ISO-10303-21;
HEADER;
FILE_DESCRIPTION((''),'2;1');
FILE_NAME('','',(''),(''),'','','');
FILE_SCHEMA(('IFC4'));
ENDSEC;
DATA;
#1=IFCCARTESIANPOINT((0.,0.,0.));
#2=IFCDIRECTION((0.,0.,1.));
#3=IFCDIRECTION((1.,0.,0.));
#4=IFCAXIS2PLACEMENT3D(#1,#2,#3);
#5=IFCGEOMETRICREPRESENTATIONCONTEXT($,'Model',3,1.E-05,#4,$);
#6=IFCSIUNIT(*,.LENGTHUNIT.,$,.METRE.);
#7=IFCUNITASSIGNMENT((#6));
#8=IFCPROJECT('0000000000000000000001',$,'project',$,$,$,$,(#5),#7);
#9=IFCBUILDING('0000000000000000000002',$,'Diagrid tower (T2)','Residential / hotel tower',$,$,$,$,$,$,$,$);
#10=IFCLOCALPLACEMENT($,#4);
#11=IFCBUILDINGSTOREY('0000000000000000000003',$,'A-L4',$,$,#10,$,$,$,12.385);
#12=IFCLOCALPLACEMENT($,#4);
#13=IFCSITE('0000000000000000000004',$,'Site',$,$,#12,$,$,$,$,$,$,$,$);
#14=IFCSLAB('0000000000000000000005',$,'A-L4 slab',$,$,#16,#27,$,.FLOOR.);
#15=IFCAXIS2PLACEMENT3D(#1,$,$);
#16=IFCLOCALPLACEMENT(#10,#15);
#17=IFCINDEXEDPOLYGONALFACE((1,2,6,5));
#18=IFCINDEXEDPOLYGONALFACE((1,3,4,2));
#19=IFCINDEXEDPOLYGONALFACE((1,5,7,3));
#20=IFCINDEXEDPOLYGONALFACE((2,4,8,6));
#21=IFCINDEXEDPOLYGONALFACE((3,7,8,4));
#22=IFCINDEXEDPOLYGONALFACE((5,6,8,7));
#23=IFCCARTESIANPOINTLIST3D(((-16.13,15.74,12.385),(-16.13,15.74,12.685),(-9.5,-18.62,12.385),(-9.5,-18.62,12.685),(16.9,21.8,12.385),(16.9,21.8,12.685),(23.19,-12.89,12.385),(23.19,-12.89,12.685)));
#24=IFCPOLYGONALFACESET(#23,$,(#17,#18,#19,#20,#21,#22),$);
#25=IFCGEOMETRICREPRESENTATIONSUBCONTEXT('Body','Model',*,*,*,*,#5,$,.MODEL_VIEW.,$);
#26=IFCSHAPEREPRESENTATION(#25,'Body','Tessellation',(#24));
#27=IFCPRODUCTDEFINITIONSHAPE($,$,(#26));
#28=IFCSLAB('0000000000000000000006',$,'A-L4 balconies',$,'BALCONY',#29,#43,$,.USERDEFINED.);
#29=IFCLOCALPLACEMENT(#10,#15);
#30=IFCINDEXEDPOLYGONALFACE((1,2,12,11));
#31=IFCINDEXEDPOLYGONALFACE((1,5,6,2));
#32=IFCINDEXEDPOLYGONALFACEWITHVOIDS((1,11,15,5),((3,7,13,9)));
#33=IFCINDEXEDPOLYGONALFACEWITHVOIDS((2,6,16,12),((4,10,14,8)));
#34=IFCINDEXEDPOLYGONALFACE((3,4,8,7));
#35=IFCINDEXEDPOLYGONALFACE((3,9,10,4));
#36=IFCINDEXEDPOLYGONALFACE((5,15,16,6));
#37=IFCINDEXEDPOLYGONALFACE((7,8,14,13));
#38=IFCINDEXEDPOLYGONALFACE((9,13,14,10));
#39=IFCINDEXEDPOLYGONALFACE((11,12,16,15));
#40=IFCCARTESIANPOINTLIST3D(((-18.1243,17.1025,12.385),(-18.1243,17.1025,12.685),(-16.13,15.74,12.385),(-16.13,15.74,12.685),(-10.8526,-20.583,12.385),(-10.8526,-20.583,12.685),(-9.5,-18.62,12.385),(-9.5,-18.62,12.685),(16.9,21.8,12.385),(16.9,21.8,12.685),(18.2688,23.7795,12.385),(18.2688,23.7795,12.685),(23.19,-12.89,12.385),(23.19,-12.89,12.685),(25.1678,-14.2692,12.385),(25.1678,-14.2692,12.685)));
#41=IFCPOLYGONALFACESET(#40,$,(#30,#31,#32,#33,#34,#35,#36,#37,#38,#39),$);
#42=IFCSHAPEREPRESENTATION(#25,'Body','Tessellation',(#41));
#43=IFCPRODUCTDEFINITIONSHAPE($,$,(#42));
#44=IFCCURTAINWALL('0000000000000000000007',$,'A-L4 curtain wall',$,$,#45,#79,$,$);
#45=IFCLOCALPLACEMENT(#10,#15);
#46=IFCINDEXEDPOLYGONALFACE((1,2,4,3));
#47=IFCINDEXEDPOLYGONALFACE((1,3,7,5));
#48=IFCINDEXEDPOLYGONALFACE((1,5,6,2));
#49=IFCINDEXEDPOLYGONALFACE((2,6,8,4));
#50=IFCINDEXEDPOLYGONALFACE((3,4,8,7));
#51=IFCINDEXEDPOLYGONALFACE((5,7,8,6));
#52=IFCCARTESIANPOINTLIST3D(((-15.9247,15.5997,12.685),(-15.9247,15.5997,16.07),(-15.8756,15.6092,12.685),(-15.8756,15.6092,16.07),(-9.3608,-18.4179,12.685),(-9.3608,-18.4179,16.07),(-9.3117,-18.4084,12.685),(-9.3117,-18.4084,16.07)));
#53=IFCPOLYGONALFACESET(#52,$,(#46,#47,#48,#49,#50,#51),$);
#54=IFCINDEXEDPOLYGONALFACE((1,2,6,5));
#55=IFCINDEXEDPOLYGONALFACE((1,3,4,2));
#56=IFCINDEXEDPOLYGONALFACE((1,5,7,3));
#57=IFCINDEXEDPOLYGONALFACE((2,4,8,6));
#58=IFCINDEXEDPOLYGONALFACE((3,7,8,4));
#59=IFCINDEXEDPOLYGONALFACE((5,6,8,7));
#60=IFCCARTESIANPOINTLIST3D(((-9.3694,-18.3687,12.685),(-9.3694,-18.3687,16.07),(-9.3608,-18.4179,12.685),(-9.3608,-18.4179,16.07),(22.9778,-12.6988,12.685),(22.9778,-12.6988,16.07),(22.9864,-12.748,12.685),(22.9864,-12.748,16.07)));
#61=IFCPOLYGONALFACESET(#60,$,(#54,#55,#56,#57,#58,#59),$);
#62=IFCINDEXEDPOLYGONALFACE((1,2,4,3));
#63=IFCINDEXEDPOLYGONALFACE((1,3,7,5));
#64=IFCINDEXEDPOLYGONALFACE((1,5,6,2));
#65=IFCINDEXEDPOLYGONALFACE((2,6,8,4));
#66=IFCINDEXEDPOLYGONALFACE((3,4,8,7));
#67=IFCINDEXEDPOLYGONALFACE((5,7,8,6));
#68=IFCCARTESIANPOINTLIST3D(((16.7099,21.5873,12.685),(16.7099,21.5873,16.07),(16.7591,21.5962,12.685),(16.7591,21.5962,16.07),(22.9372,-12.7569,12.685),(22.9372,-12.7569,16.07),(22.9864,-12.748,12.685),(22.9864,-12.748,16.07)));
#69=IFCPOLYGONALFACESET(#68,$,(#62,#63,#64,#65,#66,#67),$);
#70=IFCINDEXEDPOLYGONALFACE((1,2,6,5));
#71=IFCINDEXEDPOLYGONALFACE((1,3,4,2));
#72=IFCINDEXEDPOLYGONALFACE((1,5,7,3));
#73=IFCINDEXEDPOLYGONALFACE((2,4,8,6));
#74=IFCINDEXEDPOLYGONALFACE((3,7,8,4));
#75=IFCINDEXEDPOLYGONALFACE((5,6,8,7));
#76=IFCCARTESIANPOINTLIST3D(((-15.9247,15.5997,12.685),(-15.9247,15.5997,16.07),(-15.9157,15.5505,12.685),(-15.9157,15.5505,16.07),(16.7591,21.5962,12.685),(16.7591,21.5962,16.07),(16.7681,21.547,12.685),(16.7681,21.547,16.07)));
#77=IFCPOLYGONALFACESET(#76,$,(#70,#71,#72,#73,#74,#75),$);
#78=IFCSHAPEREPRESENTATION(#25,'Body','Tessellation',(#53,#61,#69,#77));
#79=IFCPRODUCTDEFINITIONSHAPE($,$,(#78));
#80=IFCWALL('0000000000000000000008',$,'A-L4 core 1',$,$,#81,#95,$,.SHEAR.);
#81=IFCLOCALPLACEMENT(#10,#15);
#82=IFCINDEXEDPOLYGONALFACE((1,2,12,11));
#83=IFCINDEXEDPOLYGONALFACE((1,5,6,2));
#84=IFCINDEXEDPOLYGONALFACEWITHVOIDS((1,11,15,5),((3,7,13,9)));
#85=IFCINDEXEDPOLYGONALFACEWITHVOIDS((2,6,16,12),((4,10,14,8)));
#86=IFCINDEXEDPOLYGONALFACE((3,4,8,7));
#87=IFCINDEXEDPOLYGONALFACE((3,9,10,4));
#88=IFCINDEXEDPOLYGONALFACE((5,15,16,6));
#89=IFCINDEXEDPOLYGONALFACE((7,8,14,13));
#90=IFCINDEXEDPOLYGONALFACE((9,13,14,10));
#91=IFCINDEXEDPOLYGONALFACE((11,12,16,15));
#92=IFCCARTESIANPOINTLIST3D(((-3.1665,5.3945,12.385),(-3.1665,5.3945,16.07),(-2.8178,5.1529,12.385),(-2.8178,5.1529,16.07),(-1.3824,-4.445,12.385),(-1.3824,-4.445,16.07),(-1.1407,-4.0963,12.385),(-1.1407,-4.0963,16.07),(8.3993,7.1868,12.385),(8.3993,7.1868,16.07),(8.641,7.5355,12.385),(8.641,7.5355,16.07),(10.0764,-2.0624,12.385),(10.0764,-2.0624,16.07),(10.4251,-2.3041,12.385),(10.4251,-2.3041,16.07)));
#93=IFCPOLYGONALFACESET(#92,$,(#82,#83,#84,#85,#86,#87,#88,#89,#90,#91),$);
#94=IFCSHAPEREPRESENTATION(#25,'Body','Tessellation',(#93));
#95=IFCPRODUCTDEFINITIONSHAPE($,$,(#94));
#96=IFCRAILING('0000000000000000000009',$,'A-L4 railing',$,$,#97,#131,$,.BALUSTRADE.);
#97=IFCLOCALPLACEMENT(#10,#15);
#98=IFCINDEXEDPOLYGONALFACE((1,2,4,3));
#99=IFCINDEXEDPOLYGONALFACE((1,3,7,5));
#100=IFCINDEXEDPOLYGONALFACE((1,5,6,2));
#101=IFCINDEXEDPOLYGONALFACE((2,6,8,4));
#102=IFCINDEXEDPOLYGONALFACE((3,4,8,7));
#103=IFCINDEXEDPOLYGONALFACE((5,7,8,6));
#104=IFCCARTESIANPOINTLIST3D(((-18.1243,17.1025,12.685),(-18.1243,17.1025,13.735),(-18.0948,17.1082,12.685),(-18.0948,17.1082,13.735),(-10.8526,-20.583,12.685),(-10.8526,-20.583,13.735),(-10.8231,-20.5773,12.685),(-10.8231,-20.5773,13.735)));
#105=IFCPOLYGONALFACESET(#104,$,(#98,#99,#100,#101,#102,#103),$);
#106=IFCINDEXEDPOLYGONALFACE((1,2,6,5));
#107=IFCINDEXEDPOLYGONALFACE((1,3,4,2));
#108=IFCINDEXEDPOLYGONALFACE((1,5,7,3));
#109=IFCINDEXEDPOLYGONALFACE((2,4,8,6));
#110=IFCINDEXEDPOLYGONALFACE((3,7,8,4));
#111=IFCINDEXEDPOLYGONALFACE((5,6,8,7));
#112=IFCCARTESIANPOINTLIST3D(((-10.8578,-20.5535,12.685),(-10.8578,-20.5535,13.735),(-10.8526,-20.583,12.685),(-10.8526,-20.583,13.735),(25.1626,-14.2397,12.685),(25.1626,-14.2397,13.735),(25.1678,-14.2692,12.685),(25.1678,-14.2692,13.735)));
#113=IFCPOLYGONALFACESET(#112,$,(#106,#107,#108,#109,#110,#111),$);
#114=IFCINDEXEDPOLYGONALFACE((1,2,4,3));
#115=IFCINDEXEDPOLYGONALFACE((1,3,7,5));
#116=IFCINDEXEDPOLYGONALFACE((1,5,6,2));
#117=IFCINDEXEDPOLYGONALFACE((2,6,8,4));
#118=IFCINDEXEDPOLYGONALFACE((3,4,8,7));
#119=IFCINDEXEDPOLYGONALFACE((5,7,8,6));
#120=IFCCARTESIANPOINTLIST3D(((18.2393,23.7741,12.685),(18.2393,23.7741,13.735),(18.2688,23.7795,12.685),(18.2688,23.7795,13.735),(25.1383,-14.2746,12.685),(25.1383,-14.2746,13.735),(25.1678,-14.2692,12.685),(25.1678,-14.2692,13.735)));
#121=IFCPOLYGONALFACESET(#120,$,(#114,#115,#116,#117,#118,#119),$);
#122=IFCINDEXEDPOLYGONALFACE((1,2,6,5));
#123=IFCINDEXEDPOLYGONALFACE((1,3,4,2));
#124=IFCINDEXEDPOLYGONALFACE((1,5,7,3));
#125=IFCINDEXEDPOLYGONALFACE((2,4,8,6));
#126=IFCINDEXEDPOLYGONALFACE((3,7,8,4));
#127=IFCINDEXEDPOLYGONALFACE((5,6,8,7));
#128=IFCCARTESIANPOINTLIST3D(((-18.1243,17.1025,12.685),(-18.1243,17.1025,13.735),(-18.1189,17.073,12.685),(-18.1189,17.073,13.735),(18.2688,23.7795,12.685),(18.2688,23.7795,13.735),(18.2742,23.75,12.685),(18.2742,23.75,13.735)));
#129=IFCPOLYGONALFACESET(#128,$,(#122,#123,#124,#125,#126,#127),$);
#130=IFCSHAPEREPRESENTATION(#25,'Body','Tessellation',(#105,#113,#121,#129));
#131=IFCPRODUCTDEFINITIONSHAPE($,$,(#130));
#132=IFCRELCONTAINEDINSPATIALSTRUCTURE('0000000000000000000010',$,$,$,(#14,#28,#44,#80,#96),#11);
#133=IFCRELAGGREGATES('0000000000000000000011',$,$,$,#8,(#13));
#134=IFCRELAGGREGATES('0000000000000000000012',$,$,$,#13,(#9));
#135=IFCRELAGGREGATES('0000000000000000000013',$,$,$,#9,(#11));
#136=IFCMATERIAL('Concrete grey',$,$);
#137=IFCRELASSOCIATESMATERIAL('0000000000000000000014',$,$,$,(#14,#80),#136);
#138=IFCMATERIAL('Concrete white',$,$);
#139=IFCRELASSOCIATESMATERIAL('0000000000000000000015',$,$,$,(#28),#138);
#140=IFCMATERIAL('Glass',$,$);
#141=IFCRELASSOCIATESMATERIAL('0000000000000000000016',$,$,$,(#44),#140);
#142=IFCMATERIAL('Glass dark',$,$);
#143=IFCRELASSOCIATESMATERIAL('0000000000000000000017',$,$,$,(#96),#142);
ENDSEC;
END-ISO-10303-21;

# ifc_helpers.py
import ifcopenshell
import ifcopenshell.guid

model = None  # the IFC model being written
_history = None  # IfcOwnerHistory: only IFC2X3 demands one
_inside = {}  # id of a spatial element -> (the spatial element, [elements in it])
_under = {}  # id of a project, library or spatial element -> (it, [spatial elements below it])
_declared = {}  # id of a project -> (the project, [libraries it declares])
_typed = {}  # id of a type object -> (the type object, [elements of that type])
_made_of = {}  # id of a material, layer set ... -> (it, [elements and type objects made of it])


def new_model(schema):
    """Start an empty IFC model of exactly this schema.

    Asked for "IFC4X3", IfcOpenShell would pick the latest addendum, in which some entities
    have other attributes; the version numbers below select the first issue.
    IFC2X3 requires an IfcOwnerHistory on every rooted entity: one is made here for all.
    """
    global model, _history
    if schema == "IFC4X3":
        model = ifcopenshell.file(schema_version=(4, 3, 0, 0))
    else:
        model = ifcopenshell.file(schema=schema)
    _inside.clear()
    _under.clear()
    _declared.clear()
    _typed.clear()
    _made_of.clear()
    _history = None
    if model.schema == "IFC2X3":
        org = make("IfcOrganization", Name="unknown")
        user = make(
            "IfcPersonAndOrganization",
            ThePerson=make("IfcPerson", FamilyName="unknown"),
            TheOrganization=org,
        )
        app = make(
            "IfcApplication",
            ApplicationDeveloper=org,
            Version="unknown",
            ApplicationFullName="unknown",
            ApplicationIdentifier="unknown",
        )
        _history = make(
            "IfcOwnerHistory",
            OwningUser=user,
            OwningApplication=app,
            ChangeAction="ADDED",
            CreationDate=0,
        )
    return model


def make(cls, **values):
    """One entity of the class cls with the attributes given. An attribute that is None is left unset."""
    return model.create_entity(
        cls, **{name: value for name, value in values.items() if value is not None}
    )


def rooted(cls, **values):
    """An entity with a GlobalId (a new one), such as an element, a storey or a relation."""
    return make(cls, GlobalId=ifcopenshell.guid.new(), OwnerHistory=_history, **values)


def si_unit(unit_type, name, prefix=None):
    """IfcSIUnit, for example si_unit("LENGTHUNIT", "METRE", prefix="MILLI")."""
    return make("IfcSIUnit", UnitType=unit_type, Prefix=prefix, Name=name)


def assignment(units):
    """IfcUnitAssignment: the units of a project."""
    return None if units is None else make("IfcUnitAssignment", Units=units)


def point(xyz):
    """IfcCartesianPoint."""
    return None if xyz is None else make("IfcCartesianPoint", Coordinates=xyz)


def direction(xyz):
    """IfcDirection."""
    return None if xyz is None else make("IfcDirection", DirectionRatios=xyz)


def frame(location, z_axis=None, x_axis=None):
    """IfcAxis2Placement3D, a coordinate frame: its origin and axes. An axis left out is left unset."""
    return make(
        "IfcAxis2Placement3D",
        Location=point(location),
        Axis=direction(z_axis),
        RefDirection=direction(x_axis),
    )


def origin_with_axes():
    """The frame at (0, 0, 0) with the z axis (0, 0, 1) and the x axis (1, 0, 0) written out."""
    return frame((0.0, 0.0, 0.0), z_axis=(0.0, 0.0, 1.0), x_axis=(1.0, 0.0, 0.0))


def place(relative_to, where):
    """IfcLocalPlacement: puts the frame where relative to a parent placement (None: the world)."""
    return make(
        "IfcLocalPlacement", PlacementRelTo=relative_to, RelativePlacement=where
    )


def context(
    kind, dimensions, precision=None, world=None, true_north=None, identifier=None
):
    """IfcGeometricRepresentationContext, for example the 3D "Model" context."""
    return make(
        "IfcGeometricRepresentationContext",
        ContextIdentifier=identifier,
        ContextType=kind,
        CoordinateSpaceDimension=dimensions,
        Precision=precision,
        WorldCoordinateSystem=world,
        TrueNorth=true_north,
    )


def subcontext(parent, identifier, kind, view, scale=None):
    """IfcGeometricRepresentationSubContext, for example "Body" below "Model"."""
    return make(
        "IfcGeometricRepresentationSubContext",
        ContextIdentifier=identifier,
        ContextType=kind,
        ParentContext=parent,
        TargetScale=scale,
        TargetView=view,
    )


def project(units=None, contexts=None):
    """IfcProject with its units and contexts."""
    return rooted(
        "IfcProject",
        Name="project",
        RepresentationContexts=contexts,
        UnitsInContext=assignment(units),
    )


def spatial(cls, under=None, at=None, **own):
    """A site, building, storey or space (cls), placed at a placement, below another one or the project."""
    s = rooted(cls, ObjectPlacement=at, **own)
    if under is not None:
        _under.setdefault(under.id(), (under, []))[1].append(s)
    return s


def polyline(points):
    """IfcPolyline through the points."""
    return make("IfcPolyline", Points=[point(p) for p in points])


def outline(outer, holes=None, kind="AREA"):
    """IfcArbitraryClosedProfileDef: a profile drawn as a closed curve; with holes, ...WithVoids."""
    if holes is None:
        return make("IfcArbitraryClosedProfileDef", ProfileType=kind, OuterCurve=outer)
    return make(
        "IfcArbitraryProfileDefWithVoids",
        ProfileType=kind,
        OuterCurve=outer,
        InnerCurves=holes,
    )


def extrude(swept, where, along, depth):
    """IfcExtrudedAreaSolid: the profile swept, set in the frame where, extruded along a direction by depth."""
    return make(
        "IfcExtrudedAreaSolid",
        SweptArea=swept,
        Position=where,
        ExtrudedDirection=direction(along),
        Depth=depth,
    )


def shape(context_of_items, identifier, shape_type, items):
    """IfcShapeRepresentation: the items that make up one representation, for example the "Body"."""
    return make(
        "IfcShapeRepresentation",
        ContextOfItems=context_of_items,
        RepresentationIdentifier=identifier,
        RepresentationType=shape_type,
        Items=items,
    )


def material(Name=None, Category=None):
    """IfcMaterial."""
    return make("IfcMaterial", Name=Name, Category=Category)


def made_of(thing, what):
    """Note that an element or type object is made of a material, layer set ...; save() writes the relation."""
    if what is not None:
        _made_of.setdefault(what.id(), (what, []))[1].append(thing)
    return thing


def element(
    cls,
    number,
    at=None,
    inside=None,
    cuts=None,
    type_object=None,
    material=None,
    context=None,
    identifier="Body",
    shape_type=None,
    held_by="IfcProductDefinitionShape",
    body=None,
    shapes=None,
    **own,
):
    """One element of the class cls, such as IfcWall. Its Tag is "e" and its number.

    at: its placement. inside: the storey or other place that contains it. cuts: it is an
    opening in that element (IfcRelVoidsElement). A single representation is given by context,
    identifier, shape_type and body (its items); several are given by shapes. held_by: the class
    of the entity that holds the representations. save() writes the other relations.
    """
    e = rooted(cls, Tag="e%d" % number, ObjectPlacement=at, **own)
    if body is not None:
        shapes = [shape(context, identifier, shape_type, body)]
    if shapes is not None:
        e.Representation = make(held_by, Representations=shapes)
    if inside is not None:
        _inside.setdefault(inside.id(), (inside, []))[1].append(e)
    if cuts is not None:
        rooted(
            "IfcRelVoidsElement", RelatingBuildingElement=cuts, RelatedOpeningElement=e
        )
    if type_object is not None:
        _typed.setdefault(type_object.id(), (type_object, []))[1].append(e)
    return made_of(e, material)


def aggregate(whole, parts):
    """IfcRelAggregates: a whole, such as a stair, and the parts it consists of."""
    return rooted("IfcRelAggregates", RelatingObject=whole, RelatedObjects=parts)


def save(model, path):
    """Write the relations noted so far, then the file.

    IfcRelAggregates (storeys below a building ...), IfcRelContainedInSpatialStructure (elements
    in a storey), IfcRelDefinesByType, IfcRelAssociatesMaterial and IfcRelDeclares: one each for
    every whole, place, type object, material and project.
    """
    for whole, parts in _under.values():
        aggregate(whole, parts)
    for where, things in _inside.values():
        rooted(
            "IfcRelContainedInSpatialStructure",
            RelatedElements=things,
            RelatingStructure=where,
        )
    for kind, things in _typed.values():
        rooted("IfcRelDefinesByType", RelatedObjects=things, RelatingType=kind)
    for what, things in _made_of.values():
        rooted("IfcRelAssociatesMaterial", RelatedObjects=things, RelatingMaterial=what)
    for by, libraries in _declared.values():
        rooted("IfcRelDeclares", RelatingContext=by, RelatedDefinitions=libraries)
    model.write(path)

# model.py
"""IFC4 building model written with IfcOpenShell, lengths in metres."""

from ifc_helpers import new_model, si_unit, frame, origin_with_axes, place, context, subcontext, project, spatial, polyline, outline, extrude, material, element, save


model = new_model("IFC4")

# Units and contexts
model_context = context("Model", 3, precision=1e-05, world=origin_with_axes())
body_context = subcontext(model_context, "Body", "Model", "MODEL_VIEW")
ifc_project = project(units=[si_unit("LENGTHUNIT", "METRE")], contexts=[model_context])

# Site, building, storey
site_placement = place(None, origin_with_axes())
site = spatial("IfcSite", under=ifc_project, at=site_placement, Name="Site")
building = spatial("IfcBuilding", under=site, Name="Diagrid tower (T2)", Description="Residential / hotel tower")
storey_placement = place(None, origin_with_axes())
storey = spatial("IfcBuildingStorey", under=building, at=storey_placement, Name="A-L4", Elevation=12.385)

# Slabs
ifc_material_1 = material(Name="Concrete grey")
slab_1_placement = place(storey_placement, origin_with_axes())
element("IfcSlab", 1, at=slab_1_placement, inside=storey, material=ifc_material_1, Name="A-L4 slab", PredefinedType="FLOOR", context=body_context, shape_type="SweptSolid", body=[
    extrude(outline(polyline([(-16.13, 15.74), (-9.5, -18.62), (23.19, -12.89), (16.9, 21.8), (-16.13, 15.74)])), frame((0.0, 0.0, 12.385), z_axis=(0.0, 0.0, 1.0), x_axis=(1.0, 0.0, 0.0)), (0.0, 0.0, 1.0), 0.3),
])
ifc_material_2 = material(Name="Concrete white")
slab_2_placement = place(storey_placement, origin_with_axes())
element("IfcSlab", 2, at=slab_2_placement, inside=storey, material=ifc_material_2, Name="A-L4 balconies", ObjectType="BALCONY", PredefinedType="USERDEFINED", context=body_context, shape_type="SweptSolid", body=[
    extrude(outline(polyline([(-18.1243, 17.1025), (-10.8526, -20.583), (25.1678, -14.2692), (18.2688, 23.7795), (-18.1243, 17.1025)]), holes=[polyline([(-16.13, 15.74), (-9.5, -18.62), (23.19, -12.89), (16.9, 21.8), (-16.13, 15.74)])]), frame((0.0, 0.0, 12.385), z_axis=(0.0, 0.0, 1.0), x_axis=(1.0, 0.0, 0.0)), (0.0, 0.0, 1.0), 0.3),
])

# Curtain wall
ifc_material_3 = material(Name="Glass")
curtain_wall_placement = place(storey_placement, origin_with_axes())
element("IfcCurtainWall", 3, at=curtain_wall_placement, inside=storey, material=ifc_material_3, Name="A-L4 curtain wall", context=body_context, shape_type="SweptSolid", body=[
    extrude(outline(polyline([(-15.9247, 15.5997), (-9.3608, -18.4179), (-9.3117, -18.4084), (-15.8756, 15.6092), (-15.9247, 15.5997)])), frame((0.0, 0.0, 12.685), z_axis=(0.0, 0.0, 1.0), x_axis=(1.0, 0.0, 0.0)), (0.0, 0.0, 1.0), 3.385),
    extrude(outline(polyline([(-9.3608, -18.4179), (22.9864, -12.748), (22.9778, -12.6988), (-9.3694, -18.3687), (-9.3608, -18.4179)])), frame((0.0, 0.0, 12.685), z_axis=(0.0, 0.0, 1.0), x_axis=(1.0, 0.0, 0.0)), (0.0, 0.0, 1.0), 3.385),
    extrude(outline(polyline([(22.9864, -12.748), (16.7591, 21.5962), (16.7099, 21.5873), (22.9372, -12.7569), (22.9864, -12.748)])), frame((0.0, 0.0, 12.685), z_axis=(0.0, 0.0, 1.0), x_axis=(1.0, 0.0, 0.0)), (0.0, 0.0, 1.0), 3.385),
    extrude(outline(polyline([(16.7591, 21.5962), (-15.9247, 15.5997), (-15.9157, 15.5505), (16.7681, 21.547), (16.7591, 21.5962)])), frame((0.0, 0.0, 12.685), z_axis=(0.0, 0.0, 1.0), x_axis=(1.0, 0.0, 0.0)), (0.0, 0.0, 1.0), 3.385),
])

# Wall
wall_placement = place(storey_placement, origin_with_axes())
element("IfcWall", 4, at=wall_placement, inside=storey, material=ifc_material_1, Name="A-L4 core 1", PredefinedType="SHEAR", context=body_context, shape_type="SweptSolid", body=[
    extrude(outline(polyline([(10.4251, -2.3041), (8.641, 7.5355), (-3.1665, 5.3945), (-1.3824, -4.445), (10.4251, -2.3041)]), holes=[polyline([(10.0764, -2.0624), (8.3993, 7.1868), (-2.8178, 5.1529), (-1.1407, -4.0963), (10.0764, -2.0624)])]), frame((0.0, 0.0, 12.385), z_axis=(0.0, 0.0, 1.0), x_axis=(1.0, 0.0, 0.0)), (0.0, 0.0, 1.0), 3.685),
])

# Railing
ifc_material_4 = material(Name="Glass dark")
railing_placement = place(storey_placement, origin_with_axes())
element("IfcRailing", 5, at=railing_placement, inside=storey, material=ifc_material_4, Name="A-L4 railing", PredefinedType="BALUSTRADE", context=body_context, shape_type="SweptSolid", body=[
    extrude(outline(polyline([(-18.1243, 17.1025), (-10.8526, -20.583), (-10.8231, -20.5773), (-18.0948, 17.1082), (-18.1243, 17.1025)])), frame((0.0, 0.0, 12.685), z_axis=(0.0, 0.0, 1.0), x_axis=(1.0, 0.0, 0.0)), (0.0, 0.0, 1.0), 1.05),
    extrude(outline(polyline([(-10.8526, -20.583), (25.1678, -14.2692), (25.1626, -14.2397), (-10.8578, -20.5535), (-10.8526, -20.583)])), frame((0.0, 0.0, 12.685), z_axis=(0.0, 0.0, 1.0), x_axis=(1.0, 0.0, 0.0)), (0.0, 0.0, 1.0), 1.05),
    extrude(outline(polyline([(25.1678, -14.2692), (18.2688, 23.7795), (18.2393, 23.7741), (25.1383, -14.2746), (25.1678, -14.2692)])), frame((0.0, 0.0, 12.685), z_axis=(0.0, 0.0, 1.0), x_axis=(1.0, 0.0, 0.0)), (0.0, 0.0, 1.0), 1.05),
    extrude(outline(polyline([(18.2688, 23.7795), (-18.1243, 17.1025), (-18.1189, 17.073), (18.2742, 23.75), (18.2688, 23.7795)])), frame((0.0, 0.0, 12.685), z_axis=(0.0, 0.0, 1.0), x_axis=(1.0, 0.0, 0.0)), (0.0, 0.0, 1.0), 1.05),
])

save(model, "model.ifc")
